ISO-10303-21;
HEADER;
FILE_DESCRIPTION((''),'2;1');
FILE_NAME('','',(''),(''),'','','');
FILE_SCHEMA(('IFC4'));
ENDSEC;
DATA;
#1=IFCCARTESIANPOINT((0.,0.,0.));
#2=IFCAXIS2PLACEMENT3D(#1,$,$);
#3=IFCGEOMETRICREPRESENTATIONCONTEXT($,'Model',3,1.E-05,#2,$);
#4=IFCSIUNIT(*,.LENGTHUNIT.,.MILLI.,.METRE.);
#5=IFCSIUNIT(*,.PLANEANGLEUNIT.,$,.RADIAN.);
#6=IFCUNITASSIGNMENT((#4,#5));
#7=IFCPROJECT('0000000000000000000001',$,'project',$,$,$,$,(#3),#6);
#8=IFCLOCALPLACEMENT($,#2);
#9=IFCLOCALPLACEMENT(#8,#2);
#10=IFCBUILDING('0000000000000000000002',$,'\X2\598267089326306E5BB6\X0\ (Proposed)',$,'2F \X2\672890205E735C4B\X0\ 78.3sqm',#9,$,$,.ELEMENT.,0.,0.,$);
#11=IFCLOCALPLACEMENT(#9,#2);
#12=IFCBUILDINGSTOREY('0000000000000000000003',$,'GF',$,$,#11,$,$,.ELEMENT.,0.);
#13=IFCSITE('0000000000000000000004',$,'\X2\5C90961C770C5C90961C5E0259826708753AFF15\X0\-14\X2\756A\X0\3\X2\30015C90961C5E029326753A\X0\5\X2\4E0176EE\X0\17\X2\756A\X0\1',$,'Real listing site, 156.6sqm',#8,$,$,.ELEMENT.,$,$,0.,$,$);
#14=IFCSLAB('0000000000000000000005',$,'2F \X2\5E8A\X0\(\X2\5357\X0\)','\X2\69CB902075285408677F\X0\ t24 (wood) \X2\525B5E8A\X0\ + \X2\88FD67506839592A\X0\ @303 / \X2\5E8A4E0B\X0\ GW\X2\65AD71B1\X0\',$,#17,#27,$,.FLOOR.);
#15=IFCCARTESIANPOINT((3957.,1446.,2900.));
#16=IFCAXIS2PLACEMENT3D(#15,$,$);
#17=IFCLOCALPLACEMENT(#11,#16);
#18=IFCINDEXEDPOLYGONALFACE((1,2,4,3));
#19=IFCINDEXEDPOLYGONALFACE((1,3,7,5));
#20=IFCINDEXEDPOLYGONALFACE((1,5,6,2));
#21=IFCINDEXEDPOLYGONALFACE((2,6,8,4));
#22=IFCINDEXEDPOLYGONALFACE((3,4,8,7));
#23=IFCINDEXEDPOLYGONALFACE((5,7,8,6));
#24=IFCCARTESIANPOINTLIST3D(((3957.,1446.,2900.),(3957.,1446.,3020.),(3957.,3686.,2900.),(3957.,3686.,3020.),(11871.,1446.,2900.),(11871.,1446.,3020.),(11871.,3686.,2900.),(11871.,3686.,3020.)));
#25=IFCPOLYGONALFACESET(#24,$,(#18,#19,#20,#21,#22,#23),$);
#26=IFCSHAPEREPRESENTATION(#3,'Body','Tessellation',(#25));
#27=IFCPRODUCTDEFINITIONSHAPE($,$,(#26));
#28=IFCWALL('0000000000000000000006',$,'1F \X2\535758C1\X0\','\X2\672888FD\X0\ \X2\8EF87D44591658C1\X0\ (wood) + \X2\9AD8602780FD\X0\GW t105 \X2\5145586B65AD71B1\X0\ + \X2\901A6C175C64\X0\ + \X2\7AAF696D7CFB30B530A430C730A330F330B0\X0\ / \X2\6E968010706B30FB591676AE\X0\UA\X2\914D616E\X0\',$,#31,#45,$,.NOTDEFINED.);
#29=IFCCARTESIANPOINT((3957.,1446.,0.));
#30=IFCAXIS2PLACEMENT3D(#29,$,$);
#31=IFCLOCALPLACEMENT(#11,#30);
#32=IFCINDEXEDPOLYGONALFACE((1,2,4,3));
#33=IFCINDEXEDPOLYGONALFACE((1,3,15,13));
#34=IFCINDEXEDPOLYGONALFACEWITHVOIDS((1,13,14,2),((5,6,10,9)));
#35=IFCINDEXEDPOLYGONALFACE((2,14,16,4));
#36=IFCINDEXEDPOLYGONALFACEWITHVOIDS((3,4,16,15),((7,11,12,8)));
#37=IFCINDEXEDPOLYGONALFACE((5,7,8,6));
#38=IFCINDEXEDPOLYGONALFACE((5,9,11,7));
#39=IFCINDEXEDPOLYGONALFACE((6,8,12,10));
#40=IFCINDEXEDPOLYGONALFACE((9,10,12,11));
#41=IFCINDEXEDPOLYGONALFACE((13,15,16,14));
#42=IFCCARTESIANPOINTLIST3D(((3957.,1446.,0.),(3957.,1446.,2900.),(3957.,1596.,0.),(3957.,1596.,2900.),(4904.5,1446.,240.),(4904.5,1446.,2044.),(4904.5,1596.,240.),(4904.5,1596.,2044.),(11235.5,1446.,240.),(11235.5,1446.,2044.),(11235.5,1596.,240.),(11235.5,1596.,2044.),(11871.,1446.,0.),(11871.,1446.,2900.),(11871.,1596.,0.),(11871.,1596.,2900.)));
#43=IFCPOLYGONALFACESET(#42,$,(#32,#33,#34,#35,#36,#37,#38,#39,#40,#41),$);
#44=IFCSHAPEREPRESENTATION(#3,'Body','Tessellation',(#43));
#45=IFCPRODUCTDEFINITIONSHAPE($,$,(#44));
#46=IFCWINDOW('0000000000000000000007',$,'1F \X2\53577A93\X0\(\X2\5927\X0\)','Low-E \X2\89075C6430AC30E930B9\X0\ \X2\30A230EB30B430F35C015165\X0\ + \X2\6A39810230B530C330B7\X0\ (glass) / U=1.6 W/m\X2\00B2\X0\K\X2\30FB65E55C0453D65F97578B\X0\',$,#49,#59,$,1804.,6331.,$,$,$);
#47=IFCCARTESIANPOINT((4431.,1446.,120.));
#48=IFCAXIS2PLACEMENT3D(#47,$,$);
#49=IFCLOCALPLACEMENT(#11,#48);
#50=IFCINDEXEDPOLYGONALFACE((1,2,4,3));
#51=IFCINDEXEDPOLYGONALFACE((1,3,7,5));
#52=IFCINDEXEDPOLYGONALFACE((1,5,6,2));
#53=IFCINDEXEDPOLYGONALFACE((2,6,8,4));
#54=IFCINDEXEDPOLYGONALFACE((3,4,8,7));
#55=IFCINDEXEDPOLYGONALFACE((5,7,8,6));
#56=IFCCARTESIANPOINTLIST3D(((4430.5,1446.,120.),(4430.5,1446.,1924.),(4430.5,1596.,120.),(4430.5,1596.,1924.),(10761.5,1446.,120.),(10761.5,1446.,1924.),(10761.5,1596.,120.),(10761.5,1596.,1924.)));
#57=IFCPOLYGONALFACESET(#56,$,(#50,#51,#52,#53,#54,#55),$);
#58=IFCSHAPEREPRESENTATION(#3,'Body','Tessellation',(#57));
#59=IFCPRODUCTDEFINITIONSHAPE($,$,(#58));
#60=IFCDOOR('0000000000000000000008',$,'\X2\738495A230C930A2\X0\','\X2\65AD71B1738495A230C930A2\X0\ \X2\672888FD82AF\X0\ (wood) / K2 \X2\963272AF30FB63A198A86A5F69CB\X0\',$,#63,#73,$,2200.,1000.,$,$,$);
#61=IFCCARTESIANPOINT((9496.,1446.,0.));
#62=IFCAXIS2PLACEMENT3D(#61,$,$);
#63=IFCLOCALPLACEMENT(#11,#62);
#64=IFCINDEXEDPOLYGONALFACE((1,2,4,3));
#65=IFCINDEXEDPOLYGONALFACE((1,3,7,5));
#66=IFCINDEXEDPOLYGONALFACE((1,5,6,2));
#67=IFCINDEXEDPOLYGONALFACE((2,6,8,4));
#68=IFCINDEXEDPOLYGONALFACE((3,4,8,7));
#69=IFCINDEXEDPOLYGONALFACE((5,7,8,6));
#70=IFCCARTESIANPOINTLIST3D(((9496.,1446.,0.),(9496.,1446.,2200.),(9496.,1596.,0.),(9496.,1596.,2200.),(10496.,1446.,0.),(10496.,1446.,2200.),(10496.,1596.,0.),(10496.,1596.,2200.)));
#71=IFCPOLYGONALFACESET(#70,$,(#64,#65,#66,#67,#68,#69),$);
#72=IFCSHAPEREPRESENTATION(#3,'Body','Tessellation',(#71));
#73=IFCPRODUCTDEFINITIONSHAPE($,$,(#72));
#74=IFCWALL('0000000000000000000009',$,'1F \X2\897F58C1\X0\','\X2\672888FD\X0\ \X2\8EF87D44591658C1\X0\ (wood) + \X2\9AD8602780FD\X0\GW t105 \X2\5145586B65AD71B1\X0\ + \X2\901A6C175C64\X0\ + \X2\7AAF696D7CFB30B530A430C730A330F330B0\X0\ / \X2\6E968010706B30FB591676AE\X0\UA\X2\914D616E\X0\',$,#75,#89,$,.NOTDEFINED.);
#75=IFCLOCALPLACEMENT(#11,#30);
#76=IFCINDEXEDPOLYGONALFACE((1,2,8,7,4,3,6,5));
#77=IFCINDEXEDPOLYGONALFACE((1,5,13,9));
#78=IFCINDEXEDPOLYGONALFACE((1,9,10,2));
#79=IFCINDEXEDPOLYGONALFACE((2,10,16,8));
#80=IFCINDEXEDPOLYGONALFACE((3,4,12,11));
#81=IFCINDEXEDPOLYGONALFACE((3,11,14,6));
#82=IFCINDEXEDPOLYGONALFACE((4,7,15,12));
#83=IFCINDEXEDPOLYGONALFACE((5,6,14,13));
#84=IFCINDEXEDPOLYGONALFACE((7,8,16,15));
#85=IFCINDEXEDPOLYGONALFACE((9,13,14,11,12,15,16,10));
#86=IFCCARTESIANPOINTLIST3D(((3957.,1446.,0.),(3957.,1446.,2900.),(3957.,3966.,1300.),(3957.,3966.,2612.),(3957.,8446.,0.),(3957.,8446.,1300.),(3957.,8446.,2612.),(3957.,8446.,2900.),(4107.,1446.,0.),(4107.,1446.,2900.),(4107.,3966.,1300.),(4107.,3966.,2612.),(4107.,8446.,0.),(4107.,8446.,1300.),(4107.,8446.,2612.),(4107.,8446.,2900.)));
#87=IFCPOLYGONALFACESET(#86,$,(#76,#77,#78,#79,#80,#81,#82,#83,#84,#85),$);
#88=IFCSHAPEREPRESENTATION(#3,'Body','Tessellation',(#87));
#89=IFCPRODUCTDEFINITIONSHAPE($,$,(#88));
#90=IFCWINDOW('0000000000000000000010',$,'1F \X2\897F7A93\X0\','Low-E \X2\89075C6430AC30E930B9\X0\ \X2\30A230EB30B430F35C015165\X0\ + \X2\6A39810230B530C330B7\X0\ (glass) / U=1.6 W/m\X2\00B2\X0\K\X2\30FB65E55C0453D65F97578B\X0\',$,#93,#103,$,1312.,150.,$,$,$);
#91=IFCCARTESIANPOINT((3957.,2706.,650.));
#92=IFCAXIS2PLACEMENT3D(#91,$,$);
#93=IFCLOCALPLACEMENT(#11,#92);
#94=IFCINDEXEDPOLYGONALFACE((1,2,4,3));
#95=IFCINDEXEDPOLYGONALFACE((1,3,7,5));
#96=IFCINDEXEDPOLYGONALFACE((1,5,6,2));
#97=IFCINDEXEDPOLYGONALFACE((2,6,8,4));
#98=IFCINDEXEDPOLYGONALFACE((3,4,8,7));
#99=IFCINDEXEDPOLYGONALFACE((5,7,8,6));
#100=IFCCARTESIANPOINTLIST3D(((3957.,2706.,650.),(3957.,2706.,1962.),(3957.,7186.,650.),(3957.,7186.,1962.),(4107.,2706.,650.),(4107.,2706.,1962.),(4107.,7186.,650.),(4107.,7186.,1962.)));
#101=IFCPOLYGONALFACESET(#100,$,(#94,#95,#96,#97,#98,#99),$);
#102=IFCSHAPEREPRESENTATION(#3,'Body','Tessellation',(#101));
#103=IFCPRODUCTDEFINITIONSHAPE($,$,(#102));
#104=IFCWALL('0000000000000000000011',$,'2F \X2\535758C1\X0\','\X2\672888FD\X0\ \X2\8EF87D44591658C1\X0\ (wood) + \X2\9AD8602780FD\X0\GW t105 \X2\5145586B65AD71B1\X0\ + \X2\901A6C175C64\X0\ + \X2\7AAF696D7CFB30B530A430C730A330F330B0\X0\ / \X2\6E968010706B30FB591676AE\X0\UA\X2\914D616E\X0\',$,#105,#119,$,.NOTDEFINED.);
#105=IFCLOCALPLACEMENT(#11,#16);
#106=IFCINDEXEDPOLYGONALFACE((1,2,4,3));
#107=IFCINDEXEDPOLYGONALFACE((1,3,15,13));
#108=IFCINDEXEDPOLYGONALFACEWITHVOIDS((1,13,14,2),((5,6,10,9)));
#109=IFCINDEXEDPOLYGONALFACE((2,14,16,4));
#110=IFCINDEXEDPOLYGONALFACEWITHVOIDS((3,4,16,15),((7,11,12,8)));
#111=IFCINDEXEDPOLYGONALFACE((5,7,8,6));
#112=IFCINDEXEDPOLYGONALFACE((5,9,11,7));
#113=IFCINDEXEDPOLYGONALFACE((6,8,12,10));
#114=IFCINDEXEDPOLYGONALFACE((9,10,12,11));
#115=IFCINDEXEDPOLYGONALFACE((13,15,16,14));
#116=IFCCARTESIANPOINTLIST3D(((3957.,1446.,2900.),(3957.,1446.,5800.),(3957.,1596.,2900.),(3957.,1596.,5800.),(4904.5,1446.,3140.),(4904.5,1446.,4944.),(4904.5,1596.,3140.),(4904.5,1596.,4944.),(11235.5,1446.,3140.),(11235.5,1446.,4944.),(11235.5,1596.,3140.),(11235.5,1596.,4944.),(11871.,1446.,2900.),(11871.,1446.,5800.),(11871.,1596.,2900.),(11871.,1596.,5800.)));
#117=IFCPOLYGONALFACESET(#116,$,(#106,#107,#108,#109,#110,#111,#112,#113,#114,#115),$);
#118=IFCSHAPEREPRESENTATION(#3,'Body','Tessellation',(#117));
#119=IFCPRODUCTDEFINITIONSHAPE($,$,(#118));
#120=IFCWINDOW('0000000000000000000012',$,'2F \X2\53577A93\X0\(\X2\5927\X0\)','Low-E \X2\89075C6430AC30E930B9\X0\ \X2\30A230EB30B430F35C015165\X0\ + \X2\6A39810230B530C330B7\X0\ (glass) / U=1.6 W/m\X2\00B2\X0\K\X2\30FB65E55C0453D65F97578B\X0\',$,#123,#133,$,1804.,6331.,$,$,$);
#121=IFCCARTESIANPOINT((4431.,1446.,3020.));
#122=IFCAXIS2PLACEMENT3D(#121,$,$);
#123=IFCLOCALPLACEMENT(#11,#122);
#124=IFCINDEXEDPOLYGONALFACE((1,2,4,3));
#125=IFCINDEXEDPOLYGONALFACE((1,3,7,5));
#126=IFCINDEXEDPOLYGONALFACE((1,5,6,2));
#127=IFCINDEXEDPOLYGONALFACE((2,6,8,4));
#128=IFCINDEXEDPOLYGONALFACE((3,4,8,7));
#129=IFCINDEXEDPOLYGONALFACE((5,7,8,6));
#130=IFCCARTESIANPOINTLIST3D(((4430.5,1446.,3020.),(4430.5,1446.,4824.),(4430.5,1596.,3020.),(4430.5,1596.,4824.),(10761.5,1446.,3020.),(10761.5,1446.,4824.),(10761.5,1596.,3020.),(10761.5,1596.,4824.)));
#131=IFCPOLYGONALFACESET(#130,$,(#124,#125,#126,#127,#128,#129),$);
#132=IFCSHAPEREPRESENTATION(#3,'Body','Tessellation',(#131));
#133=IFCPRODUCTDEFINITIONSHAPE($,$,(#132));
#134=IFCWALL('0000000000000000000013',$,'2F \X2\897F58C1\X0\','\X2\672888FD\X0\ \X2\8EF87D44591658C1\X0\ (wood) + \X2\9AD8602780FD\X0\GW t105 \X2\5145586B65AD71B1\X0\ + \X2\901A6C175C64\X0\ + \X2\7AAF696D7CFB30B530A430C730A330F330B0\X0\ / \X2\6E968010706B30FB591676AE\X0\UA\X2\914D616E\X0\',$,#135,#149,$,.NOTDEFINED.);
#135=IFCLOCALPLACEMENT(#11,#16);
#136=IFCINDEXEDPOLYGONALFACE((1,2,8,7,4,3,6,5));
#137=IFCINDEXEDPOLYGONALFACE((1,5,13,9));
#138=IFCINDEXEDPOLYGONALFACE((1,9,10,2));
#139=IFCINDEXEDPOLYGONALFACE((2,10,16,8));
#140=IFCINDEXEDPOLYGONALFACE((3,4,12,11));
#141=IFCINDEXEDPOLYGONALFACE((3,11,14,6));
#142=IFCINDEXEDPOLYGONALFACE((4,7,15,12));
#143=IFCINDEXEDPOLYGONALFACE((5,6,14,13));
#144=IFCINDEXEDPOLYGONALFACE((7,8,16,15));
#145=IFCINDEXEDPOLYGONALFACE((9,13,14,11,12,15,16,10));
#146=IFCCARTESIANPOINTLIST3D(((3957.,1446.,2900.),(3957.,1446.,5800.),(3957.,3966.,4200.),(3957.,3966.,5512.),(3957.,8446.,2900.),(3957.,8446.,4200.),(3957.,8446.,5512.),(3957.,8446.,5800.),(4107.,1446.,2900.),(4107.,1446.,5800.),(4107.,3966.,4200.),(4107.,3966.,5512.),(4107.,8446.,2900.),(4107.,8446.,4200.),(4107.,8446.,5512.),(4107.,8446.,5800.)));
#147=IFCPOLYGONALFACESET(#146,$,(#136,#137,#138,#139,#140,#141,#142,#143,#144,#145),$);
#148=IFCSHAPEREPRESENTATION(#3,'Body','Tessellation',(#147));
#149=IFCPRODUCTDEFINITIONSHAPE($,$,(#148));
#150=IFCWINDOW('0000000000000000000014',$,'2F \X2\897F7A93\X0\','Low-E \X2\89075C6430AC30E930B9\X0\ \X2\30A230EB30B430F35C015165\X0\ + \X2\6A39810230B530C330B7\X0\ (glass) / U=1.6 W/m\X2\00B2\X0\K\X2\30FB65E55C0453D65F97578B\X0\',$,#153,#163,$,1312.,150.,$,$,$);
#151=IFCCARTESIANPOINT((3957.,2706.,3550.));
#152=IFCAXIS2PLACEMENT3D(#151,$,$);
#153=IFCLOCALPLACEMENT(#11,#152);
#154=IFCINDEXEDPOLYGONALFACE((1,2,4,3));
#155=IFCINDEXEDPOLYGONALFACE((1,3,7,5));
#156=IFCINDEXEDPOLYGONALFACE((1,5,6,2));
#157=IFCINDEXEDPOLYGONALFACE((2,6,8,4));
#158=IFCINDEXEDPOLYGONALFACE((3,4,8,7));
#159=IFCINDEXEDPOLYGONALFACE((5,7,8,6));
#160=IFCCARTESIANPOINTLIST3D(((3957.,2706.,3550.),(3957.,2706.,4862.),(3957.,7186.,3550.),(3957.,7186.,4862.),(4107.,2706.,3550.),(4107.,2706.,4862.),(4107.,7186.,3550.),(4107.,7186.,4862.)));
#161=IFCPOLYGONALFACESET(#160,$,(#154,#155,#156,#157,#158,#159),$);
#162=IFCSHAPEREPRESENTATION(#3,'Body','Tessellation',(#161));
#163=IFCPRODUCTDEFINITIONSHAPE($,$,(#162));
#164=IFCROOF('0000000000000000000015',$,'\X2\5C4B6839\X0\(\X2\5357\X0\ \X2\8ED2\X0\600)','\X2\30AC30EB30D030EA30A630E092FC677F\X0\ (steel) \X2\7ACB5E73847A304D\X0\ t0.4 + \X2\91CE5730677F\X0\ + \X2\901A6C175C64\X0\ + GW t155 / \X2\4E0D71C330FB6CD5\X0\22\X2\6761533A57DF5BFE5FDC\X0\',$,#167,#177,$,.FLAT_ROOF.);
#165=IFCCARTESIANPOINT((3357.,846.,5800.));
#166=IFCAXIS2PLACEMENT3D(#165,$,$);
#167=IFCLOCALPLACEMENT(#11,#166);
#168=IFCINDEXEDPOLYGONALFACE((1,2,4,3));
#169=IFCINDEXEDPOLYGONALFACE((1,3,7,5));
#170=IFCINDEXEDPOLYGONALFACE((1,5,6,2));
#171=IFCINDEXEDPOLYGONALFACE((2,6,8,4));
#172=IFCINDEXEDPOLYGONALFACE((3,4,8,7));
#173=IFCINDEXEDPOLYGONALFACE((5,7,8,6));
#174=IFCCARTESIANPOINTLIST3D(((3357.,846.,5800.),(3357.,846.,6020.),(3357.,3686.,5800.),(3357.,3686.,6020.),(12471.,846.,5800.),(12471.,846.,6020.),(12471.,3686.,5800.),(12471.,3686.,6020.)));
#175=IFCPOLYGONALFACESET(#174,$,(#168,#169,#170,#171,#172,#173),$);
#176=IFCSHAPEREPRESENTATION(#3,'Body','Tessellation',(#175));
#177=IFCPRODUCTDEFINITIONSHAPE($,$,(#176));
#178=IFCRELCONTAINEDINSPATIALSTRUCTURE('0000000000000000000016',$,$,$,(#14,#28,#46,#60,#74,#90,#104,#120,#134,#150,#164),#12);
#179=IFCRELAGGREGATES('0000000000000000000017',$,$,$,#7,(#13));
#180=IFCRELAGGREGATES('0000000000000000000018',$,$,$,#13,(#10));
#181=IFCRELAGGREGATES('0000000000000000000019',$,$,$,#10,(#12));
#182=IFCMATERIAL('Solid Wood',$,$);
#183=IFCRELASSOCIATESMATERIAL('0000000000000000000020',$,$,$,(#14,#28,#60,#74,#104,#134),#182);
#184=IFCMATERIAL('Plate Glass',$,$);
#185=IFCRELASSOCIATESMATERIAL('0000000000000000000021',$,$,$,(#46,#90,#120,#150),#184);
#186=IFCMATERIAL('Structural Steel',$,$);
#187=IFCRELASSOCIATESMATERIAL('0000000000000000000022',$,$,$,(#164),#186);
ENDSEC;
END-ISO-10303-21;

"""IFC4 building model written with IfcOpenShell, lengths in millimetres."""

from ifc_helpers import new_model, si_unit, frame, frame_2d, origin, place, context, project, spatial, rectangle, extrude, material, element, fill, save


model = new_model("IFC4")

# Units and contexts
model_context = context("Model", 3, precision=1e-05, world=origin())
ifc_project = project(units=[si_unit("LENGTHUNIT", "METRE", prefix="MILLI"), si_unit("PLANEANGLEUNIT", "RADIAN")], contexts=[model_context])

# Site, building, storey
site_placement = place(None, origin())
site = spatial("IfcSite", under=ifc_project, at=site_placement, Name="岐阜県岐阜市如月町５-14番3、岐阜市錦町5丁目17番1", ObjectType="Real listing site, 156.6sqm", CompositionType="ELEMENT", RefElevation=0.0)
building_placement = place(site_placement, origin())
building = spatial("IfcBuilding", under=site, at=building_placement, Name="如月錦の家 (Proposed)", ObjectType="2F 木造平屋 78.3sqm", CompositionType="ELEMENT", ElevationOfRefHeight=0.0, ElevationOfTerrain=0.0)
storey_placement = place(building_placement, origin())
storey = spatial("IfcBuildingStorey", under=building, at=storey_placement, Name="GF", CompositionType="ELEMENT", Elevation=0.0)

# Slab
ifc_material_1 = material(Name="Solid Wood")
slab_1_placement = place(storey_placement, frame((3957.0, 1446.0, 2900.0)))
element("IfcSlab", 1, at=slab_1_placement, inside=storey, material=ifc_material_1, Name="2F 床(南)", Description="構造用合板 t24 (wood) 剛床 + 製材根太 @303 / 床下 GW断熱", PredefinedType="FLOOR", context=model_context, shape_type="SweptSolid", body=[
    extrude(rectangle(XDim=7914.0, YDim=2240.0, at=frame_2d((3957.0, 1120.0))), frame((3957.0, 1446.0, 2900.0)), (0.0, 0.0, 1.0), 120.0),
])

# Wall, openings, window, door
wall_1_placement = place(storey_placement, frame((3957.0, 1446.0, 0.0)))
wall_1 = element("IfcWall", 2, at=wall_1_placement, inside=storey, material=ifc_material_1, Name="1F 南壁", Description="木製 軸組外壁 (wood) + 高性能GW t105 充填断熱 + 通気層 + 窯業系サイディング / 準耐火・外皮UA配慮", PredefinedType="NOTDEFINED", context=model_context, shape_type="SweptSolid", body=[
    extrude(rectangle(XDim=7914.0, YDim=150.0, at=frame_2d((3957.0, 75.0))), frame((3957.0, 1446.0, 0.0)), (0.0, 0.0, 1.0), 2900.0),
])
opening_1_placement = place(storey_placement, frame((4431.0, 1446.0, 120.0)))
opening_1 = element("IfcOpeningElement", 3, at=opening_1_placement, cuts=wall_1, PredefinedType="NOTDEFINED", context=model_context, shape_type="SweptSolid", body=[
    extrude(rectangle(XDim=6331.0, YDim=150.0, at=frame_2d((3165.0, 75.0))), frame((4431.0, 1446.0, 120.0)), (0.0, 0.0, 1.0), 1804.0),
])
opening_2_placement = place(storey_placement, frame((9496.0, 1446.0, 0.0)))
opening_2 = element("IfcOpeningElement", 4, at=opening_2_placement, cuts=wall_1, PredefinedType="NOTDEFINED", context=model_context, shape_type="SweptSolid", body=[
    extrude(rectangle(XDim=1000.0, YDim=150.0, at=frame_2d((500.0, 75.0))), frame((9496.0, 1446.0, 0.0)), (0.0, 0.0, 1.0), 2200.0),
])
ifc_material_2 = material(Name="Plate Glass")
window_1_placement = place(storey_placement, frame((4431.0, 1446.0, 120.0)))
window_1 = element("IfcWindow", 5, at=window_1_placement, inside=storey, material=ifc_material_2, Name="1F 南窓(大)", Description="Low-E 複層ガラス アルゴン封入 + 樹脂サッシ (glass) / U=1.6 W/m²K・日射取得型", OverallHeight=1804.0, OverallWidth=6331.0, context=model_context, shape_type="SweptSolid", body=[
    extrude(rectangle(XDim=6331.0, YDim=150.0, at=frame_2d((3165.0, 75.0))), frame((4431.0, 1446.0, 120.0)), (0.0, 0.0, 1.0), 1804.0),
])
fill(opening_1, window_1)
door_placement = place(storey_placement, frame((9496.0, 1446.0, 0.0)))
door = element("IfcDoor", 6, at=door_placement, inside=storey, material=ifc_material_1, Name="玄関ドア", Description="断熱玄関ドア 木製芯 (wood) / K2 防犯・採風機構", OverallHeight=2200.0, OverallWidth=1000.0, context=model_context, shape_type="SweptSolid", body=[
    extrude(rectangle(XDim=1000.0, YDim=150.0, at=frame_2d((500.0, 75.0))), frame((9496.0, 1446.0, 0.0)), (0.0, 0.0, 1.0), 2200.0),
])
fill(opening_2, door)

# Walls, openings, windows
wall_2_placement = place(storey_placement, frame((3957.0, 1446.0, 0.0)))
wall_2 = element("IfcWall", 7, at=wall_2_placement, inside=storey, material=ifc_material_1, Name="1F 西壁", Description="木製 軸組外壁 (wood) + 高性能GW t105 充填断熱 + 通気層 + 窯業系サイディング / 準耐火・外皮UA配慮", PredefinedType="NOTDEFINED", context=model_context, shape_type="SweptSolid", body=[
    extrude(rectangle(XDim=150.0, YDim=7000.0, at=frame_2d((75.0, 3500.0))), frame((3957.0, 1446.0, 0.0)), (0.0, 0.0, 1.0), 2900.0),
])
opening_3_placement = place(storey_placement, frame((3957.0, 2706.0, 650.0)))
opening_3 = element("IfcOpeningElement", 8, at=opening_3_placement, cuts=wall_2, PredefinedType="NOTDEFINED", context=model_context, shape_type="SweptSolid", body=[
    extrude(rectangle(XDim=150.0, YDim=4480.0, at=frame_2d((75.0, 2240.0))), frame((3957.0, 2706.0, 650.0)), (0.0, 0.0, 1.0), 1312.0),
])
window_2_placement = place(storey_placement, frame((3957.0, 2706.0, 650.0)))
window_2 = element("IfcWindow", 9, at=window_2_placement, inside=storey, material=ifc_material_2, Name="1F 西窓", Description="Low-E 複層ガラス アルゴン封入 + 樹脂サッシ (glass) / U=1.6 W/m²K・日射取得型", OverallHeight=1312.0, OverallWidth=150.0, context=model_context, shape_type="SweptSolid", body=[
    extrude(rectangle(XDim=150.0, YDim=4480.0, at=frame_2d((75.0, 2240.0))), frame((3957.0, 2706.0, 650.0)), (0.0, 0.0, 1.0), 1312.0),
])
fill(opening_3, window_2)
wall_3_placement = place(storey_placement, frame((3957.0, 1446.0, 2900.0)))
wall_3 = element("IfcWall", 10, at=wall_3_placement, inside=storey, material=ifc_material_1, Name="2F 南壁", Description="木製 軸組外壁 (wood) + 高性能GW t105 充填断熱 + 通気層 + 窯業系サイディング / 準耐火・外皮UA配慮", PredefinedType="NOTDEFINED", context=model_context, shape_type="SweptSolid", body=[
    extrude(rectangle(XDim=7914.0, YDim=150.0, at=frame_2d((3957.0, 75.0))), frame((3957.0, 1446.0, 2900.0)), (0.0, 0.0, 1.0), 2900.0),
])
opening_4_placement = place(storey_placement, frame((4431.0, 1446.0, 3020.0)))
opening_4 = element("IfcOpeningElement", 11, at=opening_4_placement, cuts=wall_3, PredefinedType="NOTDEFINED", context=model_context, shape_type="SweptSolid", body=[
    extrude(rectangle(XDim=6331.0, YDim=150.0, at=frame_2d((3165.0, 75.0))), frame((4431.0, 1446.0, 3020.0)), (0.0, 0.0, 1.0), 1804.0),
])
window_3_placement = place(storey_placement, frame((4431.0, 1446.0, 3020.0)))
window_3 = element("IfcWindow", 12, at=window_3_placement, inside=storey, material=ifc_material_2, Name="2F 南窓(大)", Description="Low-E 複層ガラス アルゴン封入 + 樹脂サッシ (glass) / U=1.6 W/m²K・日射取得型", OverallHeight=1804.0, OverallWidth=6331.0, context=model_context, shape_type="SweptSolid", body=[
    extrude(rectangle(XDim=6331.0, YDim=150.0, at=frame_2d((3165.0, 75.0))), frame((4431.0, 1446.0, 3020.0)), (0.0, 0.0, 1.0), 1804.0),
])
fill(opening_4, window_3)
wall_4_placement = place(storey_placement, frame((3957.0, 1446.0, 2900.0)))
wall_4 = element("IfcWall", 13, at=wall_4_placement, inside=storey, material=ifc_material_1, Name="2F 西壁", Description="木製 軸組外壁 (wood) + 高性能GW t105 充填断熱 + 通気層 + 窯業系サイディング / 準耐火・外皮UA配慮", PredefinedType="NOTDEFINED", context=model_context, shape_type="SweptSolid", body=[
    extrude(rectangle(XDim=150.0, YDim=7000.0, at=frame_2d((75.0, 3500.0))), frame((3957.0, 1446.0, 2900.0)), (0.0, 0.0, 1.0), 2900.0),
])
opening_5_placement = place(storey_placement, frame((3957.0, 2706.0, 3550.0)))
opening_5 = element("IfcOpeningElement", 14, at=opening_5_placement, cuts=wall_4, PredefinedType="NOTDEFINED", context=model_context, shape_type="SweptSolid", body=[
    extrude(rectangle(XDim=150.0, YDim=4480.0, at=frame_2d((75.0, 2240.0))), frame((3957.0, 2706.0, 3550.0)), (0.0, 0.0, 1.0), 1312.0),
])
window_4_placement = place(storey_placement, frame((3957.0, 2706.0, 3550.0)))
window_4 = element("IfcWindow", 15, at=window_4_placement, inside=storey, material=ifc_material_2, Name="2F 西窓", Description="Low-E 複層ガラス アルゴン封入 + 樹脂サッシ (glass) / U=1.6 W/m²K・日射取得型", OverallHeight=1312.0, OverallWidth=150.0, context=model_context, shape_type="SweptSolid", body=[
    extrude(rectangle(XDim=150.0, YDim=4480.0, at=frame_2d((75.0, 2240.0))), frame((3957.0, 2706.0, 3550.0)), (0.0, 0.0, 1.0), 1312.0),
])
fill(opening_5, window_4)

# Roof
ifc_material_3 = material(Name="Structural Steel")
roof_1_placement = place(storey_placement, frame((3357.0, 846.0, 5800.0)))
element("IfcRoof", 16, at=roof_1_placement, inside=storey, material=ifc_material_3, Name="屋根(南 軒600)", Description="ガルバリウム鋼板 (steel) 立平葺き t0.4 + 野地板 + 通気層 + GW t155 / 不燃・法22条区域対応", PredefinedType="FLAT_ROOF", context=model_context, shape_type="SweptSolid", body=[
    extrude(rectangle(XDim=9114.0, YDim=2840.0, at=frame_2d((4557.0, 1420.0))), frame((3357.0, 846.0, 5800.0)), (0.0, 0.0, 1.0), 220.0),
])

save(model, "model.ifc")
